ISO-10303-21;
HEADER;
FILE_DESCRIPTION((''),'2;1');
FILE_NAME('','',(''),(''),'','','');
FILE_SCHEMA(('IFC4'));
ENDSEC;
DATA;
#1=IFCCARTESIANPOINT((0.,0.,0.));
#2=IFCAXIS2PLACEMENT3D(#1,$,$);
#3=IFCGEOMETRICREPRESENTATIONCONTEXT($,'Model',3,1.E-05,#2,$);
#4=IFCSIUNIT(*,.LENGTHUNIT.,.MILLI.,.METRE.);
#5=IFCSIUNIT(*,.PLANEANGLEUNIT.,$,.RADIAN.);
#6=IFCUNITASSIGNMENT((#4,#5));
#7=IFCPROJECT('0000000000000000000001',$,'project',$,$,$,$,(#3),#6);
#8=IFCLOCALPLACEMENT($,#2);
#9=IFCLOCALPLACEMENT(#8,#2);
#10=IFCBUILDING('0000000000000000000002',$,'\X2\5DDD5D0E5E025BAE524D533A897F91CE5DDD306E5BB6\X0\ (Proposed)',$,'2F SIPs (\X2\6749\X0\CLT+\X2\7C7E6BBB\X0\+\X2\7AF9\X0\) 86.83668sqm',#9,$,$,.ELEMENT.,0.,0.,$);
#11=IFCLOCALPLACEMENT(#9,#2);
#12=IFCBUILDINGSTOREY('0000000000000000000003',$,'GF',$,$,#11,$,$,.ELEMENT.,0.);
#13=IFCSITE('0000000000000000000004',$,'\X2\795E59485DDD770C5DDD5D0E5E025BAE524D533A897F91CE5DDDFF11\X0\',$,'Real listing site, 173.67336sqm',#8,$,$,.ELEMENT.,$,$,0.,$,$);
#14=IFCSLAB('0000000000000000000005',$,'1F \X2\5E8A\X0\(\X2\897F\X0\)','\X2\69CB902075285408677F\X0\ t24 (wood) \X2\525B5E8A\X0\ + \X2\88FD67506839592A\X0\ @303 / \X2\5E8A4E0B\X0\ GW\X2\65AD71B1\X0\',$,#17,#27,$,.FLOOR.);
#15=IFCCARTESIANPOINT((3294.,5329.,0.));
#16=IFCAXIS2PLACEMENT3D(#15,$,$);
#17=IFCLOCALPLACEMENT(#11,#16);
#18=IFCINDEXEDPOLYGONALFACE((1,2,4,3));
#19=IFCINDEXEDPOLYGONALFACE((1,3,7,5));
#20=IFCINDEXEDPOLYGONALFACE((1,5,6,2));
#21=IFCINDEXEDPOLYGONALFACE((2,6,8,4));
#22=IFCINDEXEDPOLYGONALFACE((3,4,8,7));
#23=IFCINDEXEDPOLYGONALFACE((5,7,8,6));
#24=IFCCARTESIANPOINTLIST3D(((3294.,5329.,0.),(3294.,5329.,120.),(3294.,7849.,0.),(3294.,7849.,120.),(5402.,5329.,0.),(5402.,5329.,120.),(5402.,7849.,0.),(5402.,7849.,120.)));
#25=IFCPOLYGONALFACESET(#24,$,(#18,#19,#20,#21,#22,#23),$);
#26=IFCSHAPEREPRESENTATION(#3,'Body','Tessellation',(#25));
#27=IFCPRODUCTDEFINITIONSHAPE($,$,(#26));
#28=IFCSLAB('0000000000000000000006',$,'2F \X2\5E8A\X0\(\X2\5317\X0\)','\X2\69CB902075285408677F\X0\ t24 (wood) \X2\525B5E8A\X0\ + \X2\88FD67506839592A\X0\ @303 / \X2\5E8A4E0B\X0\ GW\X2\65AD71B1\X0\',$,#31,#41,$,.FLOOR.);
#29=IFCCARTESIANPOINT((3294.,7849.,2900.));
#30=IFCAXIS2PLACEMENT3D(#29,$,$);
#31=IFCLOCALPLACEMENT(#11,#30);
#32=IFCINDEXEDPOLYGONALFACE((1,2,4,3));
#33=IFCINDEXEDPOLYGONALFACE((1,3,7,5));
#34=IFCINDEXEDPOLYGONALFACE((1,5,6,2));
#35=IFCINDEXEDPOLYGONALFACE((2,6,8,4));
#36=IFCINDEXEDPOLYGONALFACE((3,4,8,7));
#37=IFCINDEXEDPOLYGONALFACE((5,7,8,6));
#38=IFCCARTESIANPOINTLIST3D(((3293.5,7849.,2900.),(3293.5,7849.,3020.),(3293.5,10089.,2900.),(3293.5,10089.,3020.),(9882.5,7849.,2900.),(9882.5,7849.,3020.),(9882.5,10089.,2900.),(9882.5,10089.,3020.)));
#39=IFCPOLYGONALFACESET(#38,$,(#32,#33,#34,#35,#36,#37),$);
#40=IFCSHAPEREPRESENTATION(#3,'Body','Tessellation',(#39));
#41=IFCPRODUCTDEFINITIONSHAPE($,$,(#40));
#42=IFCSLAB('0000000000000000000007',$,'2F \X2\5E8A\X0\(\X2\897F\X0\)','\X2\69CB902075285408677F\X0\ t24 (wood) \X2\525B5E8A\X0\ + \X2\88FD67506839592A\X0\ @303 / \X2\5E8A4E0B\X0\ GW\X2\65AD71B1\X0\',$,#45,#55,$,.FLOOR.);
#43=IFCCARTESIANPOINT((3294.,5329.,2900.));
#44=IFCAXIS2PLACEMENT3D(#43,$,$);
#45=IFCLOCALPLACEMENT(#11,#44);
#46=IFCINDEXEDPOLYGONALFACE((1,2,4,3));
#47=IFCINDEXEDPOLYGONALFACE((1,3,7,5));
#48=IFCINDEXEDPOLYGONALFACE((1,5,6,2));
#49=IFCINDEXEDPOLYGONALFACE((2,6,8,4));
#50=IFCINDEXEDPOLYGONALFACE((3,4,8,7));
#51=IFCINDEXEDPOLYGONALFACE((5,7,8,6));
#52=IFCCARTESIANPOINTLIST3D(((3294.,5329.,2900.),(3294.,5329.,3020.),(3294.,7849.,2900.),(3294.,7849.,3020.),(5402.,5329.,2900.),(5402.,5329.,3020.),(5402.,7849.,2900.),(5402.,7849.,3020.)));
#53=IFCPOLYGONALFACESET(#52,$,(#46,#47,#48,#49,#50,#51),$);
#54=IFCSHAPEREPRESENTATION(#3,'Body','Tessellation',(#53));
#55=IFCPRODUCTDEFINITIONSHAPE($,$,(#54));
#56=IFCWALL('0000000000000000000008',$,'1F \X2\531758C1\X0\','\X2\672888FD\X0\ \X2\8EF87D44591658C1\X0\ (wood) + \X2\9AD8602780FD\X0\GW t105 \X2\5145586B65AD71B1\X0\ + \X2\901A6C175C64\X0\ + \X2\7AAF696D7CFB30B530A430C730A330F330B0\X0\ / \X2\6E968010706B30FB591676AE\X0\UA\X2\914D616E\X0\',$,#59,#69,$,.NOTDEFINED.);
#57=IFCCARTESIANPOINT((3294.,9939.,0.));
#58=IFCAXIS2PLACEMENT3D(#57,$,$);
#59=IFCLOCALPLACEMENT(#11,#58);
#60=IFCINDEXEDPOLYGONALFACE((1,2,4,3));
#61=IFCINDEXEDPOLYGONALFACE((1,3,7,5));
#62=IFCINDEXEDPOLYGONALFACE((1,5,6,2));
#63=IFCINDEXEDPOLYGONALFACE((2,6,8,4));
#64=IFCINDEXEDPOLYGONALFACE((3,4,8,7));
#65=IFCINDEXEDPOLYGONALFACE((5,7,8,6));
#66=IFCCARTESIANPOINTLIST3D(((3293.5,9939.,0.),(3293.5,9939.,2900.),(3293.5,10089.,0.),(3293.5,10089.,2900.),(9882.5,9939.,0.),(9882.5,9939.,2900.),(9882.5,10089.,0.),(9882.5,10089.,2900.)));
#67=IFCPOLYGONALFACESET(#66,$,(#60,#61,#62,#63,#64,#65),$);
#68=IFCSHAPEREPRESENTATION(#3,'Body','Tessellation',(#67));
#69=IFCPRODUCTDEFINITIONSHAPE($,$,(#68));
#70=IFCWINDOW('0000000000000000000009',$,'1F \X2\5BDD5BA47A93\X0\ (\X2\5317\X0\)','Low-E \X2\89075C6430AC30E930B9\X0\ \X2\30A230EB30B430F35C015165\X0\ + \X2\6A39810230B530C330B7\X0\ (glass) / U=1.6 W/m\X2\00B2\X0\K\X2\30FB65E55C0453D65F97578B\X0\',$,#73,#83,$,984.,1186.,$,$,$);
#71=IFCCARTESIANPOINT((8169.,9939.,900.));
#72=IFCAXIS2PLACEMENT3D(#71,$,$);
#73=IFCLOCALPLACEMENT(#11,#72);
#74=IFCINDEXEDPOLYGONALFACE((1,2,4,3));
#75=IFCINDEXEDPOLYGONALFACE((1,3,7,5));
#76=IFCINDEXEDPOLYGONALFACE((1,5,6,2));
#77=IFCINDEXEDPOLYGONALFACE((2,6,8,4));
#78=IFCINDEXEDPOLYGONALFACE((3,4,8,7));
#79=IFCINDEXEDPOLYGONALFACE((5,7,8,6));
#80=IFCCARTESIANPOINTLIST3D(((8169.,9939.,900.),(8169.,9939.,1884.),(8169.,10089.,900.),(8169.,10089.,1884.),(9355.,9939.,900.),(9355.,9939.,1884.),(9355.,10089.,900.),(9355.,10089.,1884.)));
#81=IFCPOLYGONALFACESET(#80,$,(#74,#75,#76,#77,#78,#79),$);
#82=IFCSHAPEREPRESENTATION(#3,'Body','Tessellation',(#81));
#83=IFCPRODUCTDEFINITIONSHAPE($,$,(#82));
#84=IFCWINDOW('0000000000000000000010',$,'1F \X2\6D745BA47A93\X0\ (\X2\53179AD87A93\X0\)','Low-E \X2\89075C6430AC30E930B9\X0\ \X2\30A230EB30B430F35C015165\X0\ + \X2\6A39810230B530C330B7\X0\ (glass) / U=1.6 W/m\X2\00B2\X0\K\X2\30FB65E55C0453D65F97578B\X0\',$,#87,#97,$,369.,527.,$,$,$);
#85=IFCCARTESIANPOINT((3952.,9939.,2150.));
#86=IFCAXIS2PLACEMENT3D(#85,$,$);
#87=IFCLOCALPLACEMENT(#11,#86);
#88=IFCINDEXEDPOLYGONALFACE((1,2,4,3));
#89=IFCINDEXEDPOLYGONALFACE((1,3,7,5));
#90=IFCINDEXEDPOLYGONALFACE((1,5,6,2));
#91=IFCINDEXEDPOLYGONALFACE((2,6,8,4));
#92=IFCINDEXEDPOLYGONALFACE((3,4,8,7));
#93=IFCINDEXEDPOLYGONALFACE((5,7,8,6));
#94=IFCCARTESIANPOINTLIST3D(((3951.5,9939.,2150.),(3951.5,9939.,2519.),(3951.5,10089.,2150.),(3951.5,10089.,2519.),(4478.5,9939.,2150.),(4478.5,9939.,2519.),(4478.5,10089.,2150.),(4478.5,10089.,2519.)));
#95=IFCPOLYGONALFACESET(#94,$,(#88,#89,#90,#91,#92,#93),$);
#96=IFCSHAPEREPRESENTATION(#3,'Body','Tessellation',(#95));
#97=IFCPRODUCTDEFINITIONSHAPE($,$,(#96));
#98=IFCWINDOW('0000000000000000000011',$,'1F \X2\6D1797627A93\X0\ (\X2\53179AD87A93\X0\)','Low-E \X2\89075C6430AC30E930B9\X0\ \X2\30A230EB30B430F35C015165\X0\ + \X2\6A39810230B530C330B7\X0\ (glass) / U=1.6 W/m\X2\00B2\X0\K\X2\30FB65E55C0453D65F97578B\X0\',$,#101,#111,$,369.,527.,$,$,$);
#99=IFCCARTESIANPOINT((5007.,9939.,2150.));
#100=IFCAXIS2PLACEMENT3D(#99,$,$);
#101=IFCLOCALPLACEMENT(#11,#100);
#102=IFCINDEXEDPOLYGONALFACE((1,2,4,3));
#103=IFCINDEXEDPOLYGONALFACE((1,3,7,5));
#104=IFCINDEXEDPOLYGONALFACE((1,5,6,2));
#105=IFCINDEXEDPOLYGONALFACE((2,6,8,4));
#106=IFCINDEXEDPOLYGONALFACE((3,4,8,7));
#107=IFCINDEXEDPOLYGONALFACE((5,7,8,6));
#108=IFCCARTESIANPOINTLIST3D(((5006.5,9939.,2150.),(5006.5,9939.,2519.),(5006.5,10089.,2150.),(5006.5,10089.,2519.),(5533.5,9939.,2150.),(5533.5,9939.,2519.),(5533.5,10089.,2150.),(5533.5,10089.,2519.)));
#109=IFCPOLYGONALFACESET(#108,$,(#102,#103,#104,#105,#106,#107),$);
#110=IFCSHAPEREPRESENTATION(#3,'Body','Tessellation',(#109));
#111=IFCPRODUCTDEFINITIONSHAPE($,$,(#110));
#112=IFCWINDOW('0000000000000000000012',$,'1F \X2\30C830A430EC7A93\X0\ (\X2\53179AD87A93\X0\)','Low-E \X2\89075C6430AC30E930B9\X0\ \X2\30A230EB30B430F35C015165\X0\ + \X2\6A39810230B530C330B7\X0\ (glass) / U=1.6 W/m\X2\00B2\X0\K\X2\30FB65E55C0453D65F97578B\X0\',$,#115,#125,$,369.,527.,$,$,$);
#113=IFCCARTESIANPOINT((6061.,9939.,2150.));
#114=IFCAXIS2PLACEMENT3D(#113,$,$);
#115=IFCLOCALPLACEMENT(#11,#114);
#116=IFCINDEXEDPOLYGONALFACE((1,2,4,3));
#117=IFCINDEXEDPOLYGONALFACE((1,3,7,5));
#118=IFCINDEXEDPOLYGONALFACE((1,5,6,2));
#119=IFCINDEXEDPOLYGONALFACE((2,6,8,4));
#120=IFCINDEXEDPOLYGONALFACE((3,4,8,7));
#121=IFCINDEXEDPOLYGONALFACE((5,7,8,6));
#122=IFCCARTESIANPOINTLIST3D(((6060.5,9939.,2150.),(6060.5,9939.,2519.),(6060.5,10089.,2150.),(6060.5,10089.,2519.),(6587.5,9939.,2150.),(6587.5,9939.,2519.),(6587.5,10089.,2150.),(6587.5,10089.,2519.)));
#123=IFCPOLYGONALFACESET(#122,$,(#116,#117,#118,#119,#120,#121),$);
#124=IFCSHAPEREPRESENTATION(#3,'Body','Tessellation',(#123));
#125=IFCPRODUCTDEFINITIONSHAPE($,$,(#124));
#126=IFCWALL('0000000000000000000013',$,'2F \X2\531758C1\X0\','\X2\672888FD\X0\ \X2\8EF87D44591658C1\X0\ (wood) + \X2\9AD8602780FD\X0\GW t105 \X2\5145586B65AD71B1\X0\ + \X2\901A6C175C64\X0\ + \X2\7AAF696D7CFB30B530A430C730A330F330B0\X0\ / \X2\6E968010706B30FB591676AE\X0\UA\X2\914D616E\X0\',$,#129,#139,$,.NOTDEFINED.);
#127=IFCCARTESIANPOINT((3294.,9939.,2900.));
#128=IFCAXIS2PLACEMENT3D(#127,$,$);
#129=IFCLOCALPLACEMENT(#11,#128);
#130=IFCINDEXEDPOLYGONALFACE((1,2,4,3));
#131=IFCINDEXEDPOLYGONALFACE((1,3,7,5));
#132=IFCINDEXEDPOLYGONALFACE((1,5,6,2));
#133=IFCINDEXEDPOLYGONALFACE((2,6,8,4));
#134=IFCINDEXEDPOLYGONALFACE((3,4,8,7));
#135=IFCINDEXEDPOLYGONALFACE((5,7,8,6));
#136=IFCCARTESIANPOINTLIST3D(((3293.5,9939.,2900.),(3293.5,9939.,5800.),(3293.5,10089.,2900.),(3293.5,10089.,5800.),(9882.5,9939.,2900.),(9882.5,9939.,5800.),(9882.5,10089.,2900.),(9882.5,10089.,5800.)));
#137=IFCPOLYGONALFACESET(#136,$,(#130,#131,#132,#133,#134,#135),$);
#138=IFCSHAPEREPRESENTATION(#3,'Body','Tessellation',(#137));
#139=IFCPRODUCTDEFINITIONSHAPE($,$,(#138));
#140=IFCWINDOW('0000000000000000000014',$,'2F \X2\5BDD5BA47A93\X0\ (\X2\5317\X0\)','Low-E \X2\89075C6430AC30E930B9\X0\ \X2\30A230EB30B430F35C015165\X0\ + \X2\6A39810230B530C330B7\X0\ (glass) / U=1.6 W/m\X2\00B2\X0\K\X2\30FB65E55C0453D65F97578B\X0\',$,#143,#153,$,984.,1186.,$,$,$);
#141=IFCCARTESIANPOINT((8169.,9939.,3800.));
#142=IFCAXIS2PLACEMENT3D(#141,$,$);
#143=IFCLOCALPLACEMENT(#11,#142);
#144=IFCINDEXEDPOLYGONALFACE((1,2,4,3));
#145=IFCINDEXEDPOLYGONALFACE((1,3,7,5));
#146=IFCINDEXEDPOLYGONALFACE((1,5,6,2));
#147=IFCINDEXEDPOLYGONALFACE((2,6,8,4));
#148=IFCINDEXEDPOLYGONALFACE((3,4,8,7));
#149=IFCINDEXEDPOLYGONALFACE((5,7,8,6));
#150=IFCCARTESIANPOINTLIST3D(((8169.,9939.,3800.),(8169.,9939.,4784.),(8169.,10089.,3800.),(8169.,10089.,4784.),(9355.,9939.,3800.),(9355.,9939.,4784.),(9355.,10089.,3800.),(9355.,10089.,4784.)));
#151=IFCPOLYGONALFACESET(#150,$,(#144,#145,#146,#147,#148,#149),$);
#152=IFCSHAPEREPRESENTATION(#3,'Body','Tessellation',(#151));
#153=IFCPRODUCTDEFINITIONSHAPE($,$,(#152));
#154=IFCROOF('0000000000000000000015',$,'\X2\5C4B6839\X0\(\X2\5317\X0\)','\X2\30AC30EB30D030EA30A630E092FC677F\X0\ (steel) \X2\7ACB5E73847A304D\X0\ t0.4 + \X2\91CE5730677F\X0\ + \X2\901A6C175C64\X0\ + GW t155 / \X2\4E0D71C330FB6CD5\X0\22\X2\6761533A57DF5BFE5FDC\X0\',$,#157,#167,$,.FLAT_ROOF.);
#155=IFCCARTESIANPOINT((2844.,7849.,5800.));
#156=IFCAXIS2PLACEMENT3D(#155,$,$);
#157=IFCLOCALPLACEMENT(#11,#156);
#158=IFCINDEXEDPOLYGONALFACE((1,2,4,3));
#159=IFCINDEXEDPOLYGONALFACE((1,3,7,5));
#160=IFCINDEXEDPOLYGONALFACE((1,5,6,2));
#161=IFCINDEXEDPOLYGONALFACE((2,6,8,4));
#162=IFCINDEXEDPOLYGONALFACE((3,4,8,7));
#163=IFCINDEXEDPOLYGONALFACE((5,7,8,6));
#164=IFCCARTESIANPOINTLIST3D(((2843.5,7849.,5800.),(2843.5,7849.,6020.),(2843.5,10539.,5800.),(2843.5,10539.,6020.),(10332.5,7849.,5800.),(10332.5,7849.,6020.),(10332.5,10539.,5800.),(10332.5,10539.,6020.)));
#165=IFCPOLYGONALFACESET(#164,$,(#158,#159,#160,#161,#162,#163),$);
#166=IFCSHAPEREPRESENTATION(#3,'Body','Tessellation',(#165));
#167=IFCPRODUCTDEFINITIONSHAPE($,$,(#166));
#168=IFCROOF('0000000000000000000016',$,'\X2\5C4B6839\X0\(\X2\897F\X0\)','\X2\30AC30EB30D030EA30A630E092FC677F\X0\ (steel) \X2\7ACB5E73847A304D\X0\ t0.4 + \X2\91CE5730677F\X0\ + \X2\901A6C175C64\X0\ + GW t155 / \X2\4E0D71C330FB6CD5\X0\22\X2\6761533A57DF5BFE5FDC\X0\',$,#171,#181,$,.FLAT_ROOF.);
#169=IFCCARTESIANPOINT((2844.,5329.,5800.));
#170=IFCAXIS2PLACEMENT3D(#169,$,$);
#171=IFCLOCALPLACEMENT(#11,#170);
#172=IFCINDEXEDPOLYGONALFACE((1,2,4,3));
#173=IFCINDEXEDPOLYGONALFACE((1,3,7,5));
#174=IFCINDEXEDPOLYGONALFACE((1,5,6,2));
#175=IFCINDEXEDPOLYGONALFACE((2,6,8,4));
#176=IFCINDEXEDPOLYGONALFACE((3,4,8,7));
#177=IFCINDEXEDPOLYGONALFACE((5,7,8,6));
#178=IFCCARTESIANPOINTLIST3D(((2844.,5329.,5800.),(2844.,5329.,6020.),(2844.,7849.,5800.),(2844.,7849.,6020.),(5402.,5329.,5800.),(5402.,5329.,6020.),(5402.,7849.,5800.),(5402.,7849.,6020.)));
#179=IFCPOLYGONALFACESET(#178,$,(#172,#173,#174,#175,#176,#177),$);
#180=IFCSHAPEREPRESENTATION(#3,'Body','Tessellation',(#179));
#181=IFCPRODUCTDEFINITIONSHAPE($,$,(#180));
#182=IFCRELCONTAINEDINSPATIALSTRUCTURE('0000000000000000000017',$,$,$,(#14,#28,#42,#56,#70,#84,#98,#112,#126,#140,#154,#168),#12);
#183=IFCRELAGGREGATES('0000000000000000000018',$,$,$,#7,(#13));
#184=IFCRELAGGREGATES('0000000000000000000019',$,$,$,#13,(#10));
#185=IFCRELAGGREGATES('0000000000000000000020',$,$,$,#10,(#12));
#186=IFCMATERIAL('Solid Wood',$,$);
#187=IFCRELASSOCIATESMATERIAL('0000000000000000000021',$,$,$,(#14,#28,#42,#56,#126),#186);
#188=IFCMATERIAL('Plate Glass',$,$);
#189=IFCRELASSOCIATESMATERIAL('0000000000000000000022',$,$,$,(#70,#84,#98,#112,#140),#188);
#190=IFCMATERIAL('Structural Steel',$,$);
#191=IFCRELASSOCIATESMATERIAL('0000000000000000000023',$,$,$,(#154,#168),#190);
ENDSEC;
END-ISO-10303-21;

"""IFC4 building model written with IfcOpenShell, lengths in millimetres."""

from ifc_helpers import new_model, si_unit, frame, frame_2d, origin, place, context, project, spatial, rectangle, extrude, material, element, fill, save


model = new_model("IFC4")

# Units and contexts
model_context = context("Model", 3, precision=1e-05, world=origin())
ifc_project = project(units=[si_unit("LENGTHUNIT", "METRE", prefix="MILLI"), si_unit("PLANEANGLEUNIT", "RADIAN")], contexts=[model_context])

# Site, building, storey
site_placement = place(None, origin())
site = spatial("IfcSite", under=ifc_project, at=site_placement, Name="神奈川県川崎市宮前区西野川１", ObjectType="Real listing site, 173.67336sqm", CompositionType="ELEMENT", RefElevation=0.0)
building_placement = place(site_placement, origin())
building = spatial("IfcBuilding", under=site, at=building_placement, Name="川崎市宮前区西野川の家 (Proposed)", ObjectType="2F SIPs (杉CLT+籾殻+竹) 86.83668sqm", CompositionType="ELEMENT", ElevationOfRefHeight=0.0, ElevationOfTerrain=0.0)
storey_placement = place(building_placement, origin())
storey = spatial("IfcBuildingStorey", under=building, at=storey_placement, Name="GF", CompositionType="ELEMENT", Elevation=0.0)

# Slabs
ifc_material_1 = material(Name="Solid Wood")
slab_1_placement = place(storey_placement, frame((3294.0, 5329.0, 0.0)))
element("IfcSlab", 1, at=slab_1_placement, inside=storey, material=ifc_material_1, Name="1F 床(西)", Description="構造用合板 t24 (wood) 剛床 + 製材根太 @303 / 床下 GW断熱", PredefinedType="FLOOR", context=model_context, shape_type="SweptSolid", body=[
    extrude(rectangle(XDim=2108.0, YDim=2520.0, at=frame_2d((1054.0, 1260.0))), frame((3294.0, 5329.0, 0.0)), (0.0, 0.0, 1.0), 120.0),
])
slab_2_placement = place(storey_placement, frame((3294.0, 7849.0, 2900.0)))
element("IfcSlab", 2, at=slab_2_placement, inside=storey, material=ifc_material_1, Name="2F 床(北)", Description="構造用合板 t24 (wood) 剛床 + 製材根太 @303 / 床下 GW断熱", PredefinedType="FLOOR", context=model_context, shape_type="SweptSolid", body=[
    extrude(rectangle(XDim=6589.0, YDim=2240.0, at=frame_2d((3294.0, 1120.0))), frame((3294.0, 7849.0, 2900.0)), (0.0, 0.0, 1.0), 120.0),
])
slab_3_placement = place(storey_placement, frame((3294.0, 5329.0, 2900.0)))
element("IfcSlab", 3, at=slab_3_placement, inside=storey, material=ifc_material_1, Name="2F 床(西)", Description="構造用合板 t24 (wood) 剛床 + 製材根太 @303 / 床下 GW断熱", PredefinedType="FLOOR", context=model_context, shape_type="SweptSolid", body=[
    extrude(rectangle(XDim=2108.0, YDim=2520.0, at=frame_2d((1054.0, 1260.0))), frame((3294.0, 5329.0, 2900.0)), (0.0, 0.0, 1.0), 120.0),
])

# Wall, openings, windows
wall_1_placement = place(storey_placement, frame((3294.0, 9939.0, 0.0)))
wall_1 = element("IfcWall", 4, at=wall_1_placement, inside=storey, material=ifc_material_1, Name="1F 北壁", Description="木製 軸組外壁 (wood) + 高性能GW t105 充填断熱 + 通気層 + 窯業系サイディング / 準耐火・外皮UA配慮", PredefinedType="NOTDEFINED", context=model_context, shape_type="SweptSolid", body=[
    extrude(rectangle(XDim=6589.0, YDim=150.0, at=frame_2d((3294.0, 75.0))), frame((3294.0, 9939.0, 0.0)), (0.0, 0.0, 1.0), 2900.0),
])
opening_1_placement = place(storey_placement, frame((8169.0, 9939.0, 900.0)))
opening_1 = element("IfcOpeningElement", 5, at=opening_1_placement, cuts=wall_1, PredefinedType="NOTDEFINED", context=model_context, shape_type="SweptSolid", body=[
    extrude(rectangle(XDim=1186.0, YDim=150.0, at=frame_2d((593.0, 75.0))), frame((8169.0, 9939.0, 900.0)), (0.0, 0.0, 1.0), 984.0),
])
opening_2_placement = place(storey_placement, frame((3952.0, 9939.0, 2150.0)))
opening_2 = element("IfcOpeningElement", 6, at=opening_2_placement, cuts=wall_1, PredefinedType="NOTDEFINED", context=model_context, shape_type="SweptSolid", body=[
    extrude(rectangle(XDim=527.0, YDim=150.0, at=frame_2d((263.0, 75.0))), frame((3952.0, 9939.0, 2150.0)), (0.0, 0.0, 1.0), 369.0),
])
opening_3_placement = place(storey_placement, frame((5007.0, 9939.0, 2150.0)))
opening_3 = element("IfcOpeningElement", 7, at=opening_3_placement, cuts=wall_1, PredefinedType="NOTDEFINED", context=model_context, shape_type="SweptSolid", body=[
    extrude(rectangle(XDim=527.0, YDim=150.0, at=frame_2d((263.0, 75.0))), frame((5007.0, 9939.0, 2150.0)), (0.0, 0.0, 1.0), 369.0),
])
opening_4_placement = place(storey_placement, frame((6061.0, 9939.0, 2150.0)))
opening_4 = element("IfcOpeningElement", 8, at=opening_4_placement, cuts=wall_1, PredefinedType="NOTDEFINED", context=model_context, shape_type="SweptSolid", body=[
    extrude(rectangle(XDim=527.0, YDim=150.0, at=frame_2d((263.0, 75.0))), frame((6061.0, 9939.0, 2150.0)), (0.0, 0.0, 1.0), 369.0),
])
ifc_material_2 = material(Name="Plate Glass")
window_1_placement = place(storey_placement, frame((8169.0, 9939.0, 900.0)))
window_1 = element("IfcWindow", 9, at=window_1_placement, inside=storey, material=ifc_material_2, Name="1F 寝室窓 (北)", Description="Low-E 複層ガラス アルゴン封入 + 樹脂サッシ (glass) / U=1.6 W/m²K・日射取得型", OverallHeight=984.0, OverallWidth=1186.0, context=model_context, shape_type="SweptSolid", body=[
    extrude(rectangle(XDim=1186.0, YDim=150.0, at=frame_2d((593.0, 75.0))), frame((8169.0, 9939.0, 900.0)), (0.0, 0.0, 1.0), 984.0),
])
fill(opening_1, window_1)
window_2_placement = place(storey_placement, frame((3952.0, 9939.0, 2150.0)))
window_2 = element("IfcWindow", 10, at=window_2_placement, inside=storey, material=ifc_material_2, Name="1F 浴室窓 (北高窓)", Description="Low-E 複層ガラス アルゴン封入 + 樹脂サッシ (glass) / U=1.6 W/m²K・日射取得型", OverallHeight=369.0, OverallWidth=527.0, context=model_context, shape_type="SweptSolid", body=[
    extrude(rectangle(XDim=527.0, YDim=150.0, at=frame_2d((263.0, 75.0))), frame((3952.0, 9939.0, 2150.0)), (0.0, 0.0, 1.0), 369.0),
])
fill(opening_2, window_2)
window_3_placement = place(storey_placement, frame((5007.0, 9939.0, 2150.0)))
window_3 = element("IfcWindow", 11, at=window_3_placement, inside=storey, material=ifc_material_2, Name="1F 洗面窓 (北高窓)", Description="Low-E 複層ガラス アルゴン封入 + 樹脂サッシ (glass) / U=1.6 W/m²K・日射取得型", OverallHeight=369.0, OverallWidth=527.0, context=model_context, shape_type="SweptSolid", body=[
    extrude(rectangle(XDim=527.0, YDim=150.0, at=frame_2d((263.0, 75.0))), frame((5007.0, 9939.0, 2150.0)), (0.0, 0.0, 1.0), 369.0),
])
fill(opening_3, window_3)
window_4_placement = place(storey_placement, frame((6061.0, 9939.0, 2150.0)))
window_4 = element("IfcWindow", 12, at=window_4_placement, inside=storey, material=ifc_material_2, Name="1F トイレ窓 (北高窓)", Description="Low-E 複層ガラス アルゴン封入 + 樹脂サッシ (glass) / U=1.6 W/m²K・日射取得型", OverallHeight=369.0, OverallWidth=527.0, context=model_context, shape_type="SweptSolid", body=[
    extrude(rectangle(XDim=527.0, YDim=150.0, at=frame_2d((263.0, 75.0))), frame((6061.0, 9939.0, 2150.0)), (0.0, 0.0, 1.0), 369.0),
])
fill(opening_4, window_4)

# Wall, opening, window
wall_2_placement = place(storey_placement, frame((3294.0, 9939.0, 2900.0)))
wall_2 = element("IfcWall", 13, at=wall_2_placement, inside=storey, material=ifc_material_1, Name="2F 北壁", Description="木製 軸組外壁 (wood) + 高性能GW t105 充填断熱 + 通気層 + 窯業系サイディング / 準耐火・外皮UA配慮", PredefinedType="NOTDEFINED", context=model_context, shape_type="SweptSolid", body=[
    extrude(rectangle(XDim=6589.0, YDim=150.0, at=frame_2d((3294.0, 75.0))), frame((3294.0, 9939.0, 2900.0)), (0.0, 0.0, 1.0), 2900.0),
])
opening_5_placement = place(storey_placement, frame((8169.0, 9939.0, 3800.0)))
opening_5 = element("IfcOpeningElement", 14, at=opening_5_placement, cuts=wall_2, PredefinedType="NOTDEFINED", context=model_context, shape_type="SweptSolid", body=[
    extrude(rectangle(XDim=1186.0, YDim=150.0, at=frame_2d((593.0, 75.0))), frame((8169.0, 9939.0, 3800.0)), (0.0, 0.0, 1.0), 984.0),
])
window_5_placement = place(storey_placement, frame((8169.0, 9939.0, 3800.0)))
window_5 = element("IfcWindow", 15, at=window_5_placement, inside=storey, material=ifc_material_2, Name="2F 寝室窓 (北)", Description="Low-E 複層ガラス アルゴン封入 + 樹脂サッシ (glass) / U=1.6 W/m²K・日射取得型", OverallHeight=984.0, OverallWidth=1186.0, context=model_context, shape_type="SweptSolid", body=[
    extrude(rectangle(XDim=1186.0, YDim=150.0, at=frame_2d((593.0, 75.0))), frame((8169.0, 9939.0, 3800.0)), (0.0, 0.0, 1.0), 984.0),
])
fill(opening_5, window_5)

# Roofs
ifc_material_3 = material(Name="Structural Steel")
for number, where, name in (
    (16, (2844.0, 7849.0, 5800.0), "屋根(北)"),
):
    element("IfcRoof", number, at=place(storey_placement, frame(where)), inside=storey, material=ifc_material_3, Name=name, Description="ガルバリウム鋼板 (steel) 立平葺き t0.4 + 野地板 + 通気層 + GW t155 / 不燃・法22条区域対応", PredefinedType="FLAT_ROOF", context=model_context, shape_type="SweptSolid", body=[
        extrude(rectangle(XDim=7489.0, YDim=2690.0, at=frame_2d((3744.0, 1345.0))), frame((2844.0, 7849.0, 5800.0)), (0.0, 0.0, 1.0), 220.0),
    ])
roof_placement = place(storey_placement, frame((2844.0, 5329.0, 5800.0)))
element("IfcRoof", 17, at=roof_placement, inside=storey, material=ifc_material_3, Name="屋根(西)", Description="ガルバリウム鋼板 (steel) 立平葺き t0.4 + 野地板 + 通気層 + GW t155 / 不燃・法22条区域対応", PredefinedType="FLAT_ROOF", context=model_context, shape_type="SweptSolid", body=[
    extrude(rectangle(XDim=2558.0, YDim=2520.0, at=frame_2d((1279.0, 1260.0))), frame((2844.0, 5329.0, 5800.0)), (0.0, 0.0, 1.0), 220.0),
])

save(model, "model.ifc")
